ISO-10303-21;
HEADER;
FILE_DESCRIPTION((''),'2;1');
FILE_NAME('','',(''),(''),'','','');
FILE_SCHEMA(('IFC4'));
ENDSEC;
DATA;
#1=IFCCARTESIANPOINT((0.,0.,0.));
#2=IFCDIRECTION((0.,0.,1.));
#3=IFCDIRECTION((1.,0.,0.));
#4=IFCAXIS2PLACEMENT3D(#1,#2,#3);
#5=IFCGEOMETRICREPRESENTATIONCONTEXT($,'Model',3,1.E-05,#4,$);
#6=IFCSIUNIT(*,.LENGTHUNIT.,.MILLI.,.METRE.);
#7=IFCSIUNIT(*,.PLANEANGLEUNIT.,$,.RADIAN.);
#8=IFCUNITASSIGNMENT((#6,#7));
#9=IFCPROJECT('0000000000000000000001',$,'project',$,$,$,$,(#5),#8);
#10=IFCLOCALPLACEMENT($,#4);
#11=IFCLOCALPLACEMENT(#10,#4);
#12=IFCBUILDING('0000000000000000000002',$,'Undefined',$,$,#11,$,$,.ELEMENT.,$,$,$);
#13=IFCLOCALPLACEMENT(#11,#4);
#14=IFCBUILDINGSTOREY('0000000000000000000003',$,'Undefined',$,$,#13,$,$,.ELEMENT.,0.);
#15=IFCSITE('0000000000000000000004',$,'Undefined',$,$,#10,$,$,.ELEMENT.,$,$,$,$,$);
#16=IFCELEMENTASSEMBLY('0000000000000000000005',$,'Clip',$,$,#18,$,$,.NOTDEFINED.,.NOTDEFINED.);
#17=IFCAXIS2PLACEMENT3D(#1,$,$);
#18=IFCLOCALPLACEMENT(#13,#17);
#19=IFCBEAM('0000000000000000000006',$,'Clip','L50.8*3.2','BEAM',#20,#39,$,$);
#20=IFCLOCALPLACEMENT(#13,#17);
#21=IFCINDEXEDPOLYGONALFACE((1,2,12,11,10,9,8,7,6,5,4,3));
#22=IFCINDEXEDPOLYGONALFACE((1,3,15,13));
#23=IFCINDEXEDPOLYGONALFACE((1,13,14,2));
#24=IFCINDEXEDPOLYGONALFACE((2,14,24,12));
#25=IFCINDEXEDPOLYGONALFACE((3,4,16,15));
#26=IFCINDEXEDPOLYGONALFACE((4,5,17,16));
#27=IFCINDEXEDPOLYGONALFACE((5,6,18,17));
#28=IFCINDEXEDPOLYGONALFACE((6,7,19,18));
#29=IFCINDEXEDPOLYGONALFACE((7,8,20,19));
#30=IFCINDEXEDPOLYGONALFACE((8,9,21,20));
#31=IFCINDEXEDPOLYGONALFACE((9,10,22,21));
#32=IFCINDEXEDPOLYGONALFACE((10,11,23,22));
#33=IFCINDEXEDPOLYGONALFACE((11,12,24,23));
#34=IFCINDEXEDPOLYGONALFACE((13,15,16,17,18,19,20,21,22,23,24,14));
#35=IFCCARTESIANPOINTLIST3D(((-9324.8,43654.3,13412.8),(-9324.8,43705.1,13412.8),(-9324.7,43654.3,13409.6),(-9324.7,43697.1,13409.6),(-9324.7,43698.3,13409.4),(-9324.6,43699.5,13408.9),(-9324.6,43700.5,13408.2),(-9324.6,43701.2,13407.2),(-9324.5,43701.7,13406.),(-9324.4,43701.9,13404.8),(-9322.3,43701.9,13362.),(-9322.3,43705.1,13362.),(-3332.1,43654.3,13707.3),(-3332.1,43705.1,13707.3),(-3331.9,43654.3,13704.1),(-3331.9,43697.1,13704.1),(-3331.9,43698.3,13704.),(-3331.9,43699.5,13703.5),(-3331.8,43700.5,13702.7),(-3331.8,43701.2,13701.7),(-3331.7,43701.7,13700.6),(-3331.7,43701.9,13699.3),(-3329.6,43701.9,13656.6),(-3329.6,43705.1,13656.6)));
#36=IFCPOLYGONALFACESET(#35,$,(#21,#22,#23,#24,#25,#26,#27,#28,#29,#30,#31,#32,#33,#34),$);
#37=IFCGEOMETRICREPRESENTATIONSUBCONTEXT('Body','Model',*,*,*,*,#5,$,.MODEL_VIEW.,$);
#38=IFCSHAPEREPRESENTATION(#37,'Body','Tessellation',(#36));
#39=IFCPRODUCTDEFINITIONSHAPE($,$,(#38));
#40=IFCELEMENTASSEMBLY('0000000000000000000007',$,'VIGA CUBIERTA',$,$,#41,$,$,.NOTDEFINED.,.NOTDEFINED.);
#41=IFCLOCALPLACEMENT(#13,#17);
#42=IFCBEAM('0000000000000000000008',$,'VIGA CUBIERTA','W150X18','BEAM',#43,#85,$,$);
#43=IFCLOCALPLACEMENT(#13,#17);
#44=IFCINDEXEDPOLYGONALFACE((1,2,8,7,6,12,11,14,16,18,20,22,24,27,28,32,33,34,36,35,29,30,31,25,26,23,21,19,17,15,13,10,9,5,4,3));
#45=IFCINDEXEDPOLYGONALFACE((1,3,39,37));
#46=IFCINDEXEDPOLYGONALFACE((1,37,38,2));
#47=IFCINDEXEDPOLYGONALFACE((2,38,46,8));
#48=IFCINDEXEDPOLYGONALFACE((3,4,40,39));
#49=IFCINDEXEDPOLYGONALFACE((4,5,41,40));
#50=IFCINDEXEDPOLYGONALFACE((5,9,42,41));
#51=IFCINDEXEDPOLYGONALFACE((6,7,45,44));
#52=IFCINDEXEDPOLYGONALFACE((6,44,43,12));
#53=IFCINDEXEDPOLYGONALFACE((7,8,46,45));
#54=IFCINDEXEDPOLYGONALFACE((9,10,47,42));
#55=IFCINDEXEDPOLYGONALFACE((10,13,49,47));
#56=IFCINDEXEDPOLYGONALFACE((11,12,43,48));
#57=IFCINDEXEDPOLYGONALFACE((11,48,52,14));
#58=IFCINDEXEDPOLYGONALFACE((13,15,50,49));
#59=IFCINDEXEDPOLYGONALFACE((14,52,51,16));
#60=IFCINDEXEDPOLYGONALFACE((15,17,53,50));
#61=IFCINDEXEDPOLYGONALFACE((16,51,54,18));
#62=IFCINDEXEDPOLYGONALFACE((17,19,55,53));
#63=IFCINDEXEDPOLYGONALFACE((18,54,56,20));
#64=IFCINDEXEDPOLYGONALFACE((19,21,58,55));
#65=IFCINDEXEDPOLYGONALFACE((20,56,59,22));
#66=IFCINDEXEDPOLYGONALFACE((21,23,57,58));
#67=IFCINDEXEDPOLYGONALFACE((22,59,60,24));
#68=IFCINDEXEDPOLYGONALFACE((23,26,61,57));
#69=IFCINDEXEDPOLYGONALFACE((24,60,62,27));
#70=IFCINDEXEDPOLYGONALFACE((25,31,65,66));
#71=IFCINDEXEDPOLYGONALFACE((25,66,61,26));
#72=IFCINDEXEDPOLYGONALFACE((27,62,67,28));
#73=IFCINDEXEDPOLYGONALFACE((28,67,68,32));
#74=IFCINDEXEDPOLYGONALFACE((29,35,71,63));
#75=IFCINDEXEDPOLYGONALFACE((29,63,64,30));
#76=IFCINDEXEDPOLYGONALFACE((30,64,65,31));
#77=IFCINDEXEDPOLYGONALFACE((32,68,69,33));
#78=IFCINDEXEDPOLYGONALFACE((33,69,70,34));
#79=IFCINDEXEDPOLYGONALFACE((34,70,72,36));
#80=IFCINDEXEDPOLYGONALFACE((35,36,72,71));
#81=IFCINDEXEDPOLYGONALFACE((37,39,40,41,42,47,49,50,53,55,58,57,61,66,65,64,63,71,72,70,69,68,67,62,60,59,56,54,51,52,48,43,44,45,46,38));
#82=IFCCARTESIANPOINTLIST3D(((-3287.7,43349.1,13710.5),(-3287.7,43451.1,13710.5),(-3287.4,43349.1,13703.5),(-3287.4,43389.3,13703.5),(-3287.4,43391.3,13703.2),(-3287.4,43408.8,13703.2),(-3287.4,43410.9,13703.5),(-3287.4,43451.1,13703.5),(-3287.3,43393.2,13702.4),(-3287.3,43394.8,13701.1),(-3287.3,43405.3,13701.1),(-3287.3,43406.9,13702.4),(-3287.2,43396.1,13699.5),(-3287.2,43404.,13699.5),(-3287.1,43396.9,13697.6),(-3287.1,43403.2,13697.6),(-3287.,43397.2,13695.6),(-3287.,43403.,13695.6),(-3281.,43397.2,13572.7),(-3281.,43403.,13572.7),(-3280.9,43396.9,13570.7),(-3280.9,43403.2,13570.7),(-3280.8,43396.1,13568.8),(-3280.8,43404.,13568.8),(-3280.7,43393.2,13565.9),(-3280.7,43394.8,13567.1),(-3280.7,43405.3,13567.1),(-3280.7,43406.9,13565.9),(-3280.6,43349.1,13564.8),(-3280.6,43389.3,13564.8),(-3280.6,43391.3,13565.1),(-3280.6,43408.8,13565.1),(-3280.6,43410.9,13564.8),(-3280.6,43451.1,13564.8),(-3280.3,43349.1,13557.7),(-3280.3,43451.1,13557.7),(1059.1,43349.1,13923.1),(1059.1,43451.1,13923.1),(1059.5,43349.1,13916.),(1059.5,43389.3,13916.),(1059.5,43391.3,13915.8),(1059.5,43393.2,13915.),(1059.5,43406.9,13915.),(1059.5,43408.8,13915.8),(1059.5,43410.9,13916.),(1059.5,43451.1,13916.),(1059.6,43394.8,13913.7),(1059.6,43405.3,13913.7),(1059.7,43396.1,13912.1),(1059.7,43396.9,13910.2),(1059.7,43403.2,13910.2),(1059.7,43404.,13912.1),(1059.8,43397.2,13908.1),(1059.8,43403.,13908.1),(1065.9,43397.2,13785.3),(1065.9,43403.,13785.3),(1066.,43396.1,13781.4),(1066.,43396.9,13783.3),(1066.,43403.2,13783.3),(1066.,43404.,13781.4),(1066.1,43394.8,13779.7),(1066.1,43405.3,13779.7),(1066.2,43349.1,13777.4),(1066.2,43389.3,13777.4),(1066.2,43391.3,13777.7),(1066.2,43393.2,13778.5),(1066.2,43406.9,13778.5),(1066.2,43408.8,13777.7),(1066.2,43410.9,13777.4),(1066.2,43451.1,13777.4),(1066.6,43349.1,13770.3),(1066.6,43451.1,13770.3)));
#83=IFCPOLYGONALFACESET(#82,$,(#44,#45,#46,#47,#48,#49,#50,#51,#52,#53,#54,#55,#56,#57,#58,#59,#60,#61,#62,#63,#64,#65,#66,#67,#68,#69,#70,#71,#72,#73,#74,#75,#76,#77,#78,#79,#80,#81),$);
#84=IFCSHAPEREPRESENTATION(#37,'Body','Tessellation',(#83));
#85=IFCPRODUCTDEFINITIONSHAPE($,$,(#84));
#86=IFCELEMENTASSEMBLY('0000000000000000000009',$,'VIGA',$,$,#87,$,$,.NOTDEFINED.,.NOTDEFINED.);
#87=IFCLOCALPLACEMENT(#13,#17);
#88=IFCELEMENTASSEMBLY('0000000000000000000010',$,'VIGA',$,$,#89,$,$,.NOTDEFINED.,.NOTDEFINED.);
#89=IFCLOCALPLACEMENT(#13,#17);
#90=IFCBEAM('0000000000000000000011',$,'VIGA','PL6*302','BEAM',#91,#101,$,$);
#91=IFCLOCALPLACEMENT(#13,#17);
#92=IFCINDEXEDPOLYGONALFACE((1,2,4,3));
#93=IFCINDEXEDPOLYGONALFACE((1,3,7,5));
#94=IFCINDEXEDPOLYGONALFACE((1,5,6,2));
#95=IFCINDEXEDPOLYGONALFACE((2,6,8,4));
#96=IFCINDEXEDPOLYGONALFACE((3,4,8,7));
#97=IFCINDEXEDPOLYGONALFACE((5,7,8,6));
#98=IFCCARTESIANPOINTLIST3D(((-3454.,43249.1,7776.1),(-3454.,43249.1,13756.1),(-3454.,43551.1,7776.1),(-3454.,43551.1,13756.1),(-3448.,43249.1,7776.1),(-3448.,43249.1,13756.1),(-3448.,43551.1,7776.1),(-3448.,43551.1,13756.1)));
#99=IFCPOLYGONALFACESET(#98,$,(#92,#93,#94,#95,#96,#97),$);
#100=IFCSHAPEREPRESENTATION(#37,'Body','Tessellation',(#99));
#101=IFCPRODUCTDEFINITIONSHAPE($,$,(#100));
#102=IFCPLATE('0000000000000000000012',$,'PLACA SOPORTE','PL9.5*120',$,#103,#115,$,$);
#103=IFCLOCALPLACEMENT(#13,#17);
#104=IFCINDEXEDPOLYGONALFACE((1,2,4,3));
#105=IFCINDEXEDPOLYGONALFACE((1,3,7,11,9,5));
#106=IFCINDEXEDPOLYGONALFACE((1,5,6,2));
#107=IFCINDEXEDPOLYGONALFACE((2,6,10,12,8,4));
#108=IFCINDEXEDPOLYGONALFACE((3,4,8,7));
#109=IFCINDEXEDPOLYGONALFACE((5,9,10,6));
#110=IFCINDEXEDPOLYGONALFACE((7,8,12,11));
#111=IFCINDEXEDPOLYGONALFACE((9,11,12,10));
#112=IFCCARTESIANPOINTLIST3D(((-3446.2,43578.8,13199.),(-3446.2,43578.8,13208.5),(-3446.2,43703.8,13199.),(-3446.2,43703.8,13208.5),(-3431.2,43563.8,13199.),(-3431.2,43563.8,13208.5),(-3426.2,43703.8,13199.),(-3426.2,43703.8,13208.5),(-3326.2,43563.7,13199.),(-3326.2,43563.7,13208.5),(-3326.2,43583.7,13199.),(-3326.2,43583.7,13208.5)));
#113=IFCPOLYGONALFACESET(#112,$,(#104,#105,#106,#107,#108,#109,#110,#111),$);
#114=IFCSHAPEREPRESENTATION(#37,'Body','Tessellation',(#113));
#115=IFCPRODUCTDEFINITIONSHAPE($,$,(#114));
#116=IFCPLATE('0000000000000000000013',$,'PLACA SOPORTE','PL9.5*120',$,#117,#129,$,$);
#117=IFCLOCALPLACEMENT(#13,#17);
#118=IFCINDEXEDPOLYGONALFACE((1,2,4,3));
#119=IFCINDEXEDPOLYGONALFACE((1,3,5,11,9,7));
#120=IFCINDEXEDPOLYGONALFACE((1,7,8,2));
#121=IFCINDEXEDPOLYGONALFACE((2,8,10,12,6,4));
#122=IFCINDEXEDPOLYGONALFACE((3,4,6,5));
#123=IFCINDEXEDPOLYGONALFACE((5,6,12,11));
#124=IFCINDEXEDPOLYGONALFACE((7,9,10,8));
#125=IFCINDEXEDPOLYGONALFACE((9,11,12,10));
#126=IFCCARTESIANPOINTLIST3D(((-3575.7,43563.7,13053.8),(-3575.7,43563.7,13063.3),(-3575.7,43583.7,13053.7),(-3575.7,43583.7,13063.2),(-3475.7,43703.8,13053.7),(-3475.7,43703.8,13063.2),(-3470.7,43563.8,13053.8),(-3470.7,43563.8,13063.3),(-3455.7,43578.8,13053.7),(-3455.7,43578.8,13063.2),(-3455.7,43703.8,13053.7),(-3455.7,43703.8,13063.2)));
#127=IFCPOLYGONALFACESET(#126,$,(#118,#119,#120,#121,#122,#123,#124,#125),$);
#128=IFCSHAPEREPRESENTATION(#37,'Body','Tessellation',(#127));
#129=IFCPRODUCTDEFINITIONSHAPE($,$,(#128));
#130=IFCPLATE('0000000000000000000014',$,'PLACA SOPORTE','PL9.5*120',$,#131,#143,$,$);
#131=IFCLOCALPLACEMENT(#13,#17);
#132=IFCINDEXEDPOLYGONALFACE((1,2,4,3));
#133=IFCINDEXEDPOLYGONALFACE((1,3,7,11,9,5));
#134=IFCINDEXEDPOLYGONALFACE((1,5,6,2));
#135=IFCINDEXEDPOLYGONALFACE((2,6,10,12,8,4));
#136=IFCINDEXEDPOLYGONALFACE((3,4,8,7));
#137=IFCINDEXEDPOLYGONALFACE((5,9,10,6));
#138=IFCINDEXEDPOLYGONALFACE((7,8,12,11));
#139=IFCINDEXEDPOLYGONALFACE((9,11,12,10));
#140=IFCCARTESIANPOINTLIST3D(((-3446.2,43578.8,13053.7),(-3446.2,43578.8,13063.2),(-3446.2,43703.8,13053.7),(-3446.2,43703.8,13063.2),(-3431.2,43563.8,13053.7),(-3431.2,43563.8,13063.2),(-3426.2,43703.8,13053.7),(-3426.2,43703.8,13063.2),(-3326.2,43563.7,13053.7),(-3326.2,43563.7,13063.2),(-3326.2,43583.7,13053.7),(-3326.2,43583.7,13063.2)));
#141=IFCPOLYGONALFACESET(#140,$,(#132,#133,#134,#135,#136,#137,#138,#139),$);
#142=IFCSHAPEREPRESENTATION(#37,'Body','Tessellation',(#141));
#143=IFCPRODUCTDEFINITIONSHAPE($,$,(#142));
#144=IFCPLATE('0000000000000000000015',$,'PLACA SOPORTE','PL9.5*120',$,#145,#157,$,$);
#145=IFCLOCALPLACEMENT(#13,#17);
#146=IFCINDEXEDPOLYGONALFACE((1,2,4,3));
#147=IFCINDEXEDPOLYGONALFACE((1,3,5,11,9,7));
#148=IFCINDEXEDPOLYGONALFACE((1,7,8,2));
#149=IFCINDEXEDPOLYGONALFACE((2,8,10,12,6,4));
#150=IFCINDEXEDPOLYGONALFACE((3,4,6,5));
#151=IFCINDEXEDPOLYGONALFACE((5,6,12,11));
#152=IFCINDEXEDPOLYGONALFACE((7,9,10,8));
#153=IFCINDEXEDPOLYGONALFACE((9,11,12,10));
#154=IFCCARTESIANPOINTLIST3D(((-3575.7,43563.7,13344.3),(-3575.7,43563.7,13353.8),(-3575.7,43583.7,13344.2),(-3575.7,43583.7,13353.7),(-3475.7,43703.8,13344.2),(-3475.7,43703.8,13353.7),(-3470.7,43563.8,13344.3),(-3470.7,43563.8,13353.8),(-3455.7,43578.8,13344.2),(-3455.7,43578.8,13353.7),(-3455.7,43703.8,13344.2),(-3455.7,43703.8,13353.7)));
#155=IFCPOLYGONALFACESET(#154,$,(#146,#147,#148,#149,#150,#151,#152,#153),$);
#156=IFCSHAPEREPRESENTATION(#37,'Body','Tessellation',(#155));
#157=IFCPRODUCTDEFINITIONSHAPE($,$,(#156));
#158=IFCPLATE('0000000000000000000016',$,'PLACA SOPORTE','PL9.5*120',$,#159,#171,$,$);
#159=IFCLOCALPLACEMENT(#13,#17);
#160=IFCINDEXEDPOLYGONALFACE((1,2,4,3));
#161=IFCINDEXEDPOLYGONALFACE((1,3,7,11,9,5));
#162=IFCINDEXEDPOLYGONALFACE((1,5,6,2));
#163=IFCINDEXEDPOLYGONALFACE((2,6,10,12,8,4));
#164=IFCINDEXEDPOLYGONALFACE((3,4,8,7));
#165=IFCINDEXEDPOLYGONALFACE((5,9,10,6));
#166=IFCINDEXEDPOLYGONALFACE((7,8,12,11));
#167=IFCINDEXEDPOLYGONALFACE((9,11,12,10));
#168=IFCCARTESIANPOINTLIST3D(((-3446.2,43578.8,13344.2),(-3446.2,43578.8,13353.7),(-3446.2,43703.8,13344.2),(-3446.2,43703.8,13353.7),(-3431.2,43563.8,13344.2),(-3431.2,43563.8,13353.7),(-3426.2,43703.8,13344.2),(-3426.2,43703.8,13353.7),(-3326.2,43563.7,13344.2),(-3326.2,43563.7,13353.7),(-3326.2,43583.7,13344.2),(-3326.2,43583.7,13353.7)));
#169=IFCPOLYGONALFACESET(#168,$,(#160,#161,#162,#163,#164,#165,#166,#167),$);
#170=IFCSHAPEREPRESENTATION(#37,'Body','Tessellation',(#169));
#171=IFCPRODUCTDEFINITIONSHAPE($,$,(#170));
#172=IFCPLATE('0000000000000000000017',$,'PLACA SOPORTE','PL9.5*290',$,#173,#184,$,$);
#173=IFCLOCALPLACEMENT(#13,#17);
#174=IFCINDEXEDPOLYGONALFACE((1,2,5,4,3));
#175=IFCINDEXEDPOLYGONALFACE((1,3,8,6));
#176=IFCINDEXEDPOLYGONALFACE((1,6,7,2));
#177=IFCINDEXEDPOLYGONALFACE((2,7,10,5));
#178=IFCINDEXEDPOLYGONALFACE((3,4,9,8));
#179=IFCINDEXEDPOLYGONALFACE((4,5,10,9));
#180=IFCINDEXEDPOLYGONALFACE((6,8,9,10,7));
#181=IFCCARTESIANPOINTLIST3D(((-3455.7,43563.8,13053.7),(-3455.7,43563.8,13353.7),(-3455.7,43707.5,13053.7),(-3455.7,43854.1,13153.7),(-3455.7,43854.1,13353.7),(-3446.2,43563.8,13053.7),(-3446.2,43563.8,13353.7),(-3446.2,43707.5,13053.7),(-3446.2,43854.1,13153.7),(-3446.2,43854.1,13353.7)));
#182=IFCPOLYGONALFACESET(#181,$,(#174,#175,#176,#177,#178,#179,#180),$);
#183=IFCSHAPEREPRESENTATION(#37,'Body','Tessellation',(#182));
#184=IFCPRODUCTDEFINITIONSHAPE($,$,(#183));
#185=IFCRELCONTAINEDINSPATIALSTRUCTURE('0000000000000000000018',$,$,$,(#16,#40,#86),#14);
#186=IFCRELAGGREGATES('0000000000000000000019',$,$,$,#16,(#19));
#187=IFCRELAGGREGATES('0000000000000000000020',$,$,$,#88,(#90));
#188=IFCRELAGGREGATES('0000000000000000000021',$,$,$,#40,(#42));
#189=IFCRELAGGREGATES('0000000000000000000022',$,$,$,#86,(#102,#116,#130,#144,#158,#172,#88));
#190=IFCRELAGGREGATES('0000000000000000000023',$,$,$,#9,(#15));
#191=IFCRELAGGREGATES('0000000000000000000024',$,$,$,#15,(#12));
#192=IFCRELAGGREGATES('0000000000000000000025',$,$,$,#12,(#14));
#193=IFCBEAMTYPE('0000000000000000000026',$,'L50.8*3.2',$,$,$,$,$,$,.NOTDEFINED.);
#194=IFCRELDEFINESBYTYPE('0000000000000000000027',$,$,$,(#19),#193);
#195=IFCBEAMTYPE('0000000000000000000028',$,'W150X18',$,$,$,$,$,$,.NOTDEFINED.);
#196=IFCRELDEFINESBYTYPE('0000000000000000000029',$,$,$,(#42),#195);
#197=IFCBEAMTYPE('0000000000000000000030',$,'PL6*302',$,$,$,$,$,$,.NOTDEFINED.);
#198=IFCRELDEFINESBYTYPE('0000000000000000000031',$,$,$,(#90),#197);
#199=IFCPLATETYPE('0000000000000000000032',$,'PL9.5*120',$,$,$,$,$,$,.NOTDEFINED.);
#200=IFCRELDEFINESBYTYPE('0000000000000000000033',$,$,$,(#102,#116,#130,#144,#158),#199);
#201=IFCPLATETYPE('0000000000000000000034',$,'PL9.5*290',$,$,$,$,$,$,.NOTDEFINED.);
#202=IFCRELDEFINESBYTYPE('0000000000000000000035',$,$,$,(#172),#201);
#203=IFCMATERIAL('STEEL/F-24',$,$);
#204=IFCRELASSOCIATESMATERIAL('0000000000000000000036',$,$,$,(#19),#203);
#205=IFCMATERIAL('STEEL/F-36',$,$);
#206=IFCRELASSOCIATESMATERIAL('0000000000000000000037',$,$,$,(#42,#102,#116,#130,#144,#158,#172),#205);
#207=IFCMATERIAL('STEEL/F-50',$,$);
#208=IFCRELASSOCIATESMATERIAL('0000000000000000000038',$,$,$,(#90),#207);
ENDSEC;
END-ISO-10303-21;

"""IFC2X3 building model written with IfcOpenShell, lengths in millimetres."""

from ifc_helpers import new_model, si_unit, frame, origin_with_axes, origin_2d_with_axis, place, context, subcontext, project, spatial, polyline, rectangle, i_section, l_section, outline, extrude, material, type_object, element, aggregate, save


model = new_model("IFC2X3")

# Units and contexts
model_context = context("Model", 3, precision=1e-05, world=origin_with_axes())
body_context = subcontext(model_context, "Body", "Model", "MODEL_VIEW")
ifc_project = project(units=[si_unit("LENGTHUNIT", "METRE", prefix="MILLI"), si_unit("PLANEANGLEUNIT", "RADIAN")], contexts=[model_context])

# Site, building, storey
site_placement = place(None, origin_with_axes())
site = spatial("IfcSite", under=ifc_project, at=site_placement, Name="Undefined", CompositionType="ELEMENT")
building_placement = place(site_placement, origin_with_axes())
building = spatial("IfcBuilding", under=site, at=building_placement, Name="Undefined", CompositionType="ELEMENT")
storey_placement = place(building_placement, origin_with_axes())
storey = spatial("IfcBuildingStorey", under=building, at=storey_placement, Name="Undefined", CompositionType="ELEMENT", Elevation=0.0)

# Element assemblies, beams
assembly_1_placement = place(storey_placement, origin_with_axes())
assembly_1 = element("IfcElementAssembly", 1, at=assembly_1_placement, inside=storey, Name="Clip", AssemblyPlace="NOTDEFINED", PredefinedType="NOTDEFINED")
ifc_material_1 = material(Name="STEEL/F-24")
beam_type_1 = type_object("IfcBeamType", Name="L50.8*3.2", PredefinedType="NOTDEFINED")
beam_1_placement = place(assembly_1_placement, frame((-3330.8, 43679.7, 13681.9), z_axis=(0.04909, 0.0, -0.998794), x_axis=(-0.998794, 0.0, -0.04909)))
beam_1 = element("IfcBeam", 2, at=beam_1_placement, type_object=beam_type_1, material=ifc_material_1, Name="Clip", Description="L50.8*3.2", ObjectType="BEAM", context=body_context, shape_type="SweptSolid", body=[
    extrude(l_section(Depth=50.8, Width=50.8, Thickness=3.2, FilletRadius=4.8, at=origin_2d_with_axis()), frame((6000.0, 0.0, 0.0), z_axis=(-1.0, 0.0, 0.0), x_axis=(0.0, -1.0, 0.0)), (0.0, 0.0, 1.0), 6000.0),
])
aggregate(assembly_1, [beam_1])
assembly_2_placement = place(storey_placement, origin_with_axes())
assembly_2 = element("IfcElementAssembly", 3, at=assembly_2_placement, inside=storey, Name="VIGA CUBIERTA", AssemblyPlace="NOTDEFINED", PredefinedType="NOTDEFINED")
ifc_material_2 = material(Name="STEEL/F-36")
beam_type_2 = type_object("IfcBeamType", Name="W150X18", PredefinedType="NOTDEFINED")
beam_2_placement = place(assembly_2_placement, frame((-3284.0, 43400.1, 13634.1), z_axis=(-0.048847, 0.0, 0.998806), x_axis=(0.998806, 0.0, 0.048847)))
beam_2 = element("IfcBeam", 4, at=beam_2_placement, type_object=beam_type_2, material=ifc_material_2, Name="VIGA CUBIERTA", Description="W150X18", ObjectType="BEAM", context=body_context, shape_type="SweptSolid", body=[
    extrude(i_section(OverallWidth=102.0, OverallDepth=153.0, WebThickness=5.8, FlangeThickness=7.1, FilletRadius=7.9, at=origin_2d_with_axis()), frame((4352.1, 0.0, 0.0), z_axis=(-1.0, 0.0, 0.0), x_axis=(0.0, -1.0, 0.0)), (0.0, 0.0, 1.0), 4352.1),
])

# Element assemblies, beam
assembly_3_placement = place(storey_placement, origin_with_axes())
assembly_3 = element("IfcElementAssembly", 5, at=assembly_3_placement, inside=storey, Name="VIGA", AssemblyPlace="NOTDEFINED", PredefinedType="NOTDEFINED")
assembly_4_placement = place(assembly_3_placement, origin_with_axes())
assembly_4 = element("IfcElementAssembly", 6, at=assembly_4_placement, Name="VIGA", AssemblyPlace="NOTDEFINED", PredefinedType="NOTDEFINED")
ifc_material_3 = material(Name="STEEL/F-50")
beam_type_3 = type_object("IfcBeamType", Name="PL6*302", PredefinedType="NOTDEFINED")
beam_3_placement = place(assembly_4_placement, frame((-3451.0, 43400.1, 13756.1), z_axis=(0.0, 1.0, 0.0), x_axis=(0.0, 0.0, -1.0)))
beam_3 = element("IfcBeam", 7, at=beam_3_placement, type_object=beam_type_3, material=ifc_material_3, Name="VIGA", Description="PL6*302", ObjectType="BEAM", context=body_context, shape_type="SweptSolid", body=[
    extrude(rectangle(XDim=6.0, YDim=302.0, at=origin_2d_with_axis()), frame((5980.0, 0.0, 0.0), z_axis=(-1.0, 0.0, 0.0), x_axis=(0.0, -1.0, 0.0)), (0.0, 0.0, 1.0), 5980.0),
])
aggregate(assembly_4, [beam_3])

# Plates
plate_type_1 = type_object("IfcPlateType", Name="PL9.5*120", PredefinedType="NOTDEFINED")
plate_1_placement = place(assembly_3_placement, frame((-3446.2, 43563.8, 13203.7), z_axis=(0.0, 0.000071, 1.0), x_axis=(1.0, -0.000359, 0.0)))
plate_1 = element("IfcPlate", 8, at=plate_1_placement, type_object=plate_type_1, material=ifc_material_2, Name="PLACA SOPORTE", Description="PL9.5*120", context=body_context, shape_type="SweptSolid", body=[
    extrude(outline(polyline([(0.0, 15.0), (15.0, 0.0), (120.0, 0.0), (120.0, 20.0), (19.9, 140.0), (-0.1, 140.0), (0.0, 15.0)])), frame((0.0, 0.0, -4.8), z_axis=(0.0, 0.0, 1.0), x_axis=(1.0, 0.0, 0.0)), (0.0, 0.0, 1.0), 9.5),
])
plate_2_placement = place(assembly_3_placement, frame((-3455.7, 43563.8, 13058.5), z_axis=(0.0, -0.000071, -1.0), x_axis=(-1.0, -0.000359, 0.0)))
plate_2 = element("IfcPlate", 9, at=plate_2_placement, type_object=plate_type_1, material=ifc_material_2, Name="PLACA SOPORTE", Description="PL9.5*120", context=body_context, shape_type="SweptSolid", body=[
    extrude(outline(polyline([(0.0, 15.0), (15.0, 0.0), (120.0, 0.0), (120.0, 20.0), (19.9, 140.0), (-0.1, 140.0), (0.0, 15.0)])), frame((0.0, 0.0, -4.8), z_axis=(0.0, 0.0, 1.0), x_axis=(1.0, 0.0, 0.0)), (0.0, 0.0, 1.0), 9.5),
])
plate_3_placement = place(assembly_3_placement, frame((-3446.2, 43563.8, 13058.5), z_axis=(0.0, 0.000071, 1.0), x_axis=(1.0, -0.000359, 0.0)))
plate_3 = element("IfcPlate", 10, at=plate_3_placement, type_object=plate_type_1, material=ifc_material_2, Name="PLACA SOPORTE", Description="PL9.5*120", context=body_context, shape_type="SweptSolid", body=[
    extrude(outline(polyline([(0.0, 15.0), (15.0, 0.0), (120.0, 0.0), (120.0, 20.0), (19.9, 140.0), (-0.1, 140.0), (0.0, 15.0)])), frame((0.0, 0.0, -4.8), z_axis=(0.0, 0.0, 1.0), x_axis=(1.0, 0.0, 0.0)), (0.0, 0.0, 1.0), 9.5),
])
plate_4_placement = place(assembly_3_placement, frame((-3455.7, 43563.8, 13349.0), z_axis=(0.0, -0.000071, -1.0), x_axis=(-1.0, -0.000359, 0.0)))
plate_4 = element("IfcPlate", 11, at=plate_4_placement, type_object=plate_type_1, material=ifc_material_2, Name="PLACA SOPORTE", Description="PL9.5*120", context=body_context, shape_type="SweptSolid", body=[
    extrude(outline(polyline([(0.0, 15.0), (15.0, 0.0), (120.0, 0.0), (120.0, 20.0), (19.9, 140.0), (-0.1, 140.0), (0.0, 15.0)])), frame((0.0, 0.0, -4.8), z_axis=(0.0, 0.0, 1.0), x_axis=(1.0, 0.0, 0.0)), (0.0, 0.0, 1.0), 9.5),
])
plate_5_placement = place(assembly_3_placement, frame((-3446.2, 43563.8, 13349.0), z_axis=(0.0, 0.000071, 1.0), x_axis=(1.0, -0.000359, 0.0)))
plate_5 = element("IfcPlate", 12, at=plate_5_placement, type_object=plate_type_1, material=ifc_material_2, Name="PLACA SOPORTE", Description="PL9.5*120", context=body_context, shape_type="SweptSolid", body=[
    extrude(outline(polyline([(0.0, 15.0), (15.0, 0.0), (120.0, 0.0), (120.0, 20.0), (19.9, 140.0), (-0.1, 140.0), (0.0, 15.0)])), frame((0.0, 0.0, -4.8), z_axis=(0.0, 0.0, 1.0), x_axis=(1.0, 0.0, 0.0)), (0.0, 0.0, 1.0), 9.5),
])
plate_type_2 = type_object("IfcPlateType", Name="PL9.5*290", PredefinedType="NOTDEFINED")
plate_6_placement = place(assembly_3_placement, frame((-3451.0, 43563.8, 13353.7), z_axis=(-1.0, 0.000005, 0.0), x_axis=(0.000005, 1.0, 0.0)))
plate_6 = element("IfcPlate", 13, at=plate_6_placement, type_object=plate_type_2, material=ifc_material_2, Name="PLACA SOPORTE", Description="PL9.5*290", context=body_context, shape_type="SweptSolid", body=[
    extrude(outline(polyline([(0.0, 0.0), (290.3, 0.0), (290.3, 200.0), (143.7, 300.0), (0.0, 300.0), (0.0, 0.0)])), frame((0.0, 0.0, -4.8), z_axis=(0.0, 0.0, 1.0), x_axis=(1.0, 0.0, 0.0)), (0.0, 0.0, 1.0), 9.5),
])

aggregate(assembly_2, [beam_2])

aggregate(assembly_3, [plate_1, plate_2, plate_3, plate_4, plate_5, plate_6, assembly_4])

save(model, "model.ifc")
